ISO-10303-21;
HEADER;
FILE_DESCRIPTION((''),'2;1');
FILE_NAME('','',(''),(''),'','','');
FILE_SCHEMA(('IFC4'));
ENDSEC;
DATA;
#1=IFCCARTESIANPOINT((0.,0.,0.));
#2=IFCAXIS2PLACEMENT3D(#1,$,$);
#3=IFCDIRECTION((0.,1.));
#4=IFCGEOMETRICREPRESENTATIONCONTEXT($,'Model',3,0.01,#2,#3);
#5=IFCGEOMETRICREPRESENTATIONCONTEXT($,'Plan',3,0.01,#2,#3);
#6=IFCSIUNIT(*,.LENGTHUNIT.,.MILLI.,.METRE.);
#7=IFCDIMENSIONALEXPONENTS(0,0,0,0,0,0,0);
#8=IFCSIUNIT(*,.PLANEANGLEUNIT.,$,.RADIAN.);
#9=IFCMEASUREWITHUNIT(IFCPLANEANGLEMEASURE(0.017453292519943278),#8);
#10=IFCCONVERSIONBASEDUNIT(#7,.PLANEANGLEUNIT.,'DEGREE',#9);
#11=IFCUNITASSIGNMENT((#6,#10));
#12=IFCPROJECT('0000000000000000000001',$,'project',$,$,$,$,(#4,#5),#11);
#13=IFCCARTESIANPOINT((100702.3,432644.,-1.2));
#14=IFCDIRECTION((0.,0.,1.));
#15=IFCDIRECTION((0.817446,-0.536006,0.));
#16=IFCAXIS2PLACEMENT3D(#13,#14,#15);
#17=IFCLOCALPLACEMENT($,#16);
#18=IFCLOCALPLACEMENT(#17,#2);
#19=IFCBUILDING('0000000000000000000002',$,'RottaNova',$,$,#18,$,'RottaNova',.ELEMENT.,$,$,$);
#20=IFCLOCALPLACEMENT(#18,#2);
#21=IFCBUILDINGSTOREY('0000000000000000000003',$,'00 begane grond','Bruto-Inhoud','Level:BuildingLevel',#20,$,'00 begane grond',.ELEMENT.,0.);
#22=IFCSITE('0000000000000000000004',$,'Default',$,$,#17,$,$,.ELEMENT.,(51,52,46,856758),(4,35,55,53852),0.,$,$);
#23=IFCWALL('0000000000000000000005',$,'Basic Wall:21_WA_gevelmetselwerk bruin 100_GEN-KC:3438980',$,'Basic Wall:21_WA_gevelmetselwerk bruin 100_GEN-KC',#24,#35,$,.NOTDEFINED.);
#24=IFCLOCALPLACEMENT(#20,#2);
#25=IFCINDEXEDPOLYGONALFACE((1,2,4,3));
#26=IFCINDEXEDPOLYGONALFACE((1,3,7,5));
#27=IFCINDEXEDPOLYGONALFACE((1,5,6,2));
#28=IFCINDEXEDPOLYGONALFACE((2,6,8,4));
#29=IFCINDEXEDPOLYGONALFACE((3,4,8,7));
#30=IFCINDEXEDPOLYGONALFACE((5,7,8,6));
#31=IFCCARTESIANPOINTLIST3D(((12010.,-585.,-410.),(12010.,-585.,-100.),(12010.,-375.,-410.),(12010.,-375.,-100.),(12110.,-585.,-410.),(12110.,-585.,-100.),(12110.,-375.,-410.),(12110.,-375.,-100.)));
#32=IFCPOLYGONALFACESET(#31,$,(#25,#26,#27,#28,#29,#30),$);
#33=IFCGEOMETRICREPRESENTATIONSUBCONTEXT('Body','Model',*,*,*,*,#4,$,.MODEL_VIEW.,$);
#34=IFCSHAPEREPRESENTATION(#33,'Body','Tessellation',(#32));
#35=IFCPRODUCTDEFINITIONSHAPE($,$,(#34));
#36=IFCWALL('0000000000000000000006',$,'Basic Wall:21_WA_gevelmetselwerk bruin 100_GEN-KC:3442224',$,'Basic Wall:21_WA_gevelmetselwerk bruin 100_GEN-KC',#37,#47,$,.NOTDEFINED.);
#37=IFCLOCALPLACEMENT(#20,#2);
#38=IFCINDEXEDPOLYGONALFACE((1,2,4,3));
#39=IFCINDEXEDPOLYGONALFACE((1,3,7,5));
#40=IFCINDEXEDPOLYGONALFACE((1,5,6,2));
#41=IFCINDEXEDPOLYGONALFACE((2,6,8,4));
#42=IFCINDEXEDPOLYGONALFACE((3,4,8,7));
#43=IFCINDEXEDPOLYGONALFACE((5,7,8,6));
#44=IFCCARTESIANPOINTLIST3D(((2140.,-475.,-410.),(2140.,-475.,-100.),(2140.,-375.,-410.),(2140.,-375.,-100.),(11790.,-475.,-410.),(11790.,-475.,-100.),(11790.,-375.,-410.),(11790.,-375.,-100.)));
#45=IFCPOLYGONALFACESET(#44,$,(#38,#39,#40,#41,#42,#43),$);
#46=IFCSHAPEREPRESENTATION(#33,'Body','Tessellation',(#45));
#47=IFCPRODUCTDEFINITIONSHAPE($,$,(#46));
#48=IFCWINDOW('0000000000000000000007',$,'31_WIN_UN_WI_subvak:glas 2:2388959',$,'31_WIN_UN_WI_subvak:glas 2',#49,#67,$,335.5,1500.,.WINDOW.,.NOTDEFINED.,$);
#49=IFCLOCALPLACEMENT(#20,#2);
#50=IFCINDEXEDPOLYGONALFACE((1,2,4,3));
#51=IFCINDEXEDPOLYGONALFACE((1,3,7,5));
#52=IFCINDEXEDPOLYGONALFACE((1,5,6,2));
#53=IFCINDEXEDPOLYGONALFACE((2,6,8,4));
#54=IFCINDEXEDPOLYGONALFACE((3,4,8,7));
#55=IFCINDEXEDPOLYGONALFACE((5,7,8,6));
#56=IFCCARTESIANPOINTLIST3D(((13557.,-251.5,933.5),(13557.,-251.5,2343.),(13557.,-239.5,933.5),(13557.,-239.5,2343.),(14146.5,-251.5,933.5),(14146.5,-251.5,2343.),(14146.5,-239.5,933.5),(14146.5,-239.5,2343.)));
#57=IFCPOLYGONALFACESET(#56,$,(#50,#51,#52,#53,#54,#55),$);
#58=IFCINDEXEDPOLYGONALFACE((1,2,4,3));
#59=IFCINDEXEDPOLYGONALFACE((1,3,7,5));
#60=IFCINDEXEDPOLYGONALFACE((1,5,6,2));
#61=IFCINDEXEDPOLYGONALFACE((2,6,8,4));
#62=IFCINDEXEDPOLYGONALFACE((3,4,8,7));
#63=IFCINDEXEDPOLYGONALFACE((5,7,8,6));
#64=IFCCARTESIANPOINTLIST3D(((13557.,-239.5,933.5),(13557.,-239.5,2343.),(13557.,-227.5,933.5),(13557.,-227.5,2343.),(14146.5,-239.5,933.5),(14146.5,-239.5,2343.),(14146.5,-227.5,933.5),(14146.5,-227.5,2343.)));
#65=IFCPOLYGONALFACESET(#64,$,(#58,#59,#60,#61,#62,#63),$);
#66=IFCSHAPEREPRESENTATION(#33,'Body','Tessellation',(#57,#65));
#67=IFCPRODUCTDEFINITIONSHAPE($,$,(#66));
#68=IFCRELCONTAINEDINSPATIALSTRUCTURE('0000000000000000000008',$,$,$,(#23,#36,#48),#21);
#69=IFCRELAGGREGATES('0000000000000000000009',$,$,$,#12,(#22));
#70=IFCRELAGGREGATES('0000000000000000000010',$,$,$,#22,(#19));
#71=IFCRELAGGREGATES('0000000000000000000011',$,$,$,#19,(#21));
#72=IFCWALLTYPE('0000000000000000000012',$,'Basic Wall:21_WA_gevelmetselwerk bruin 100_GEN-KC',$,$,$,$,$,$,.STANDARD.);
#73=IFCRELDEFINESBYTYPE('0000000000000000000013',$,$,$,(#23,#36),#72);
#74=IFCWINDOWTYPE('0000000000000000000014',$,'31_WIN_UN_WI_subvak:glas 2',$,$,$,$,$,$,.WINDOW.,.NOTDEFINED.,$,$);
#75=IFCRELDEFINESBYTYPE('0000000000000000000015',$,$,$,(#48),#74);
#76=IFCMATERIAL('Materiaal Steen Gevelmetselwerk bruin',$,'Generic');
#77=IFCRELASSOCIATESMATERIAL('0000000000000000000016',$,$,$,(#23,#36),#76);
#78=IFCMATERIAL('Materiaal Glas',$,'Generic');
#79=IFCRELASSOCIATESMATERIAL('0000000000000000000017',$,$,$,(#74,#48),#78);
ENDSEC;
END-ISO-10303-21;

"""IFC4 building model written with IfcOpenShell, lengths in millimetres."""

from ifc_helpers import new_model, entity, si_unit, converted_unit, direction, frame, origin, place, context, subcontext, project, spatial, indexed_curve, outline, extrude, source, transform, mapped, material, type_object, type_shapes, element, save


model = new_model("IFC4")

# Units and contexts
model_context = context("Model", 3, precision=0.01, world=origin(), true_north=direction((0.0, 1.0)))
plan_context = context("Plan", 3, precision=0.01, world=origin(), true_north=direction((0.0, 1.0)))
body_context = subcontext(model_context, "Body", "Model", "MODEL_VIEW")
ifc_project = project(units=[si_unit("LENGTHUNIT", "METRE", prefix="MILLI"), converted_unit("PLANEANGLEUNIT", "DEGREE", entity("IfcPlaneAngleMeasure", 0.017453292519943278), si_unit("PLANEANGLEUNIT", "RADIAN"), dimensions=[0, 0, 0, 0, 0, 0, 0])], contexts=[model_context, plan_context])

# Site, building, storey
site_placement = place(None, frame((100702.3, 432644.0, -1.2), z_axis=(0.0, 0.0, 1.0), x_axis=(0.817446, -0.536006, 0.0)))
site = spatial("IfcSite", under=ifc_project, at=site_placement, Name="Default", CompositionType="ELEMENT", RefLatitude=(51, 52, 46, 856758), RefLongitude=(4, 35, 55, 53852), RefElevation=0.0)
building_placement = place(site_placement, origin())
building = spatial("IfcBuilding", under=site, at=building_placement, Name="RottaNova", LongName="RottaNova", CompositionType="ELEMENT")
storey_placement = place(building_placement, origin())
storey = spatial("IfcBuildingStorey", under=building, at=storey_placement, Name="00 begane grond", Description="Bruto-Inhoud", ObjectType="Level:BuildingLevel", LongName="00 begane grond", CompositionType="ELEMENT", Elevation=0.0)

# Shared definitions
ifc_material_1 = material(Name="Materiaal Glas", Category="Generic")

# Walls
ifc_material_2 = material(Name="Materiaal Steen Gevelmetselwerk bruin", Category="Generic")
wall_type_1 = type_object("IfcWallType", Name="Basic Wall:21_WA_gevelmetselwerk bruin 100_GEN-KC", PredefinedType="STANDARD")
wall_1_placement = place(storey_placement, frame((12060.0, -585.0, -410.0), z_axis=(0.0, 0.0, 1.0), x_axis=(0.0, 1.0, 0.0)))
element("IfcWall", 1, at=wall_1_placement, inside=storey, type_object=wall_type_1, material=ifc_material_2, Name="Basic Wall:21_WA_gevelmetselwerk bruin 100_GEN-KC:3438980", ObjectType="Basic Wall:21_WA_gevelmetselwerk bruin 100_GEN-KC", PredefinedType="NOTDEFINED", context=body_context, shape_type="SweptSolid", body=[
    extrude(outline(indexed_curve([(210.0, 50.0), (0.0, 50.0), (0.0, -50.0), (210.0, -50.0), (210.0, 50.0)], self_intersect=False)), origin(), (0.0, 0.0, 1.0), 310.0),
])
wall_2_placement = place(storey_placement, frame((11790.0, -425.0, -410.0), z_axis=(0.0, 0.0, 1.0), x_axis=(-1.0, 0.0, 0.0)))
element("IfcWall", 2, at=wall_2_placement, inside=storey, type_object=wall_type_1, material=ifc_material_2, Name="Basic Wall:21_WA_gevelmetselwerk bruin 100_GEN-KC:3442224", ObjectType="Basic Wall:21_WA_gevelmetselwerk bruin 100_GEN-KC", PredefinedType="NOTDEFINED", context=body_context, shape_type="SweptSolid", body=[
    extrude(outline(indexed_curve([(9650.0, 50.0), (0.0, 50.0), (0.0, -50.0), (9650.0, -50.0), (9650.0, 50.0)], self_intersect=False)), origin(), (0.0, 0.0, 1.0), 310.0),
])

# Window
window_type = type_object("IfcWindowType", Name="31_WIN_UN_WI_subvak:glas 2", PartitioningType="NOTDEFINED", PredefinedType="WINDOW", material=ifc_material_1)
shared_shape_1 = source(origin(), body_context, "Body", "SweptSolid", [
    extrude(outline(indexed_curve([(-6.0, -294.7), (6.0, -294.7), (6.0, 294.7), (-6.0, 294.7), (-6.0, -294.7)], self_intersect=False)), frame((0.0, 6.0, 0.0), z_axis=(0.0, 0.0, 1.0), x_axis=(0.0, -1.0, 0.0)), (0.0, 0.0, 1.0), 1409.5),
    extrude(outline(indexed_curve([(-6.0, -294.8), (6.0, -294.8), (6.0, 294.8), (-6.0, 294.8), (-6.0, -294.8)], self_intersect=False)), frame((0.0, -6.0, 0.0), z_axis=(0.0, 0.0, 1.0), x_axis=(0.0, -1.0, 0.0)), (0.0, 0.0, 1.0), 1409.5),
])
type_shapes(window_type, [shared_shape_1])
window_1_placement = place(storey_placement, frame((13851.8, -239.5, 933.5), z_axis=(0.0, 0.0, 1.0), x_axis=(-1.0, 0.0, 0.0)))
element("IfcWindow", 3, at=window_1_placement, inside=storey, type_object=window_type, material=ifc_material_1, Name="31_WIN_UN_WI_subvak:glas 2:2388959", ObjectType="31_WIN_UN_WI_subvak:glas 2", OverallHeight=335.5, OverallWidth=1500.0, PartitioningType="NOTDEFINED", PredefinedType="WINDOW", context=body_context, shape_type="MappedRepresentation", body=[
    mapped(shared_shape_1, transform((0.0, 0.0, 0.0), scale=1.0)),
])

save(model, "model.ifc")
